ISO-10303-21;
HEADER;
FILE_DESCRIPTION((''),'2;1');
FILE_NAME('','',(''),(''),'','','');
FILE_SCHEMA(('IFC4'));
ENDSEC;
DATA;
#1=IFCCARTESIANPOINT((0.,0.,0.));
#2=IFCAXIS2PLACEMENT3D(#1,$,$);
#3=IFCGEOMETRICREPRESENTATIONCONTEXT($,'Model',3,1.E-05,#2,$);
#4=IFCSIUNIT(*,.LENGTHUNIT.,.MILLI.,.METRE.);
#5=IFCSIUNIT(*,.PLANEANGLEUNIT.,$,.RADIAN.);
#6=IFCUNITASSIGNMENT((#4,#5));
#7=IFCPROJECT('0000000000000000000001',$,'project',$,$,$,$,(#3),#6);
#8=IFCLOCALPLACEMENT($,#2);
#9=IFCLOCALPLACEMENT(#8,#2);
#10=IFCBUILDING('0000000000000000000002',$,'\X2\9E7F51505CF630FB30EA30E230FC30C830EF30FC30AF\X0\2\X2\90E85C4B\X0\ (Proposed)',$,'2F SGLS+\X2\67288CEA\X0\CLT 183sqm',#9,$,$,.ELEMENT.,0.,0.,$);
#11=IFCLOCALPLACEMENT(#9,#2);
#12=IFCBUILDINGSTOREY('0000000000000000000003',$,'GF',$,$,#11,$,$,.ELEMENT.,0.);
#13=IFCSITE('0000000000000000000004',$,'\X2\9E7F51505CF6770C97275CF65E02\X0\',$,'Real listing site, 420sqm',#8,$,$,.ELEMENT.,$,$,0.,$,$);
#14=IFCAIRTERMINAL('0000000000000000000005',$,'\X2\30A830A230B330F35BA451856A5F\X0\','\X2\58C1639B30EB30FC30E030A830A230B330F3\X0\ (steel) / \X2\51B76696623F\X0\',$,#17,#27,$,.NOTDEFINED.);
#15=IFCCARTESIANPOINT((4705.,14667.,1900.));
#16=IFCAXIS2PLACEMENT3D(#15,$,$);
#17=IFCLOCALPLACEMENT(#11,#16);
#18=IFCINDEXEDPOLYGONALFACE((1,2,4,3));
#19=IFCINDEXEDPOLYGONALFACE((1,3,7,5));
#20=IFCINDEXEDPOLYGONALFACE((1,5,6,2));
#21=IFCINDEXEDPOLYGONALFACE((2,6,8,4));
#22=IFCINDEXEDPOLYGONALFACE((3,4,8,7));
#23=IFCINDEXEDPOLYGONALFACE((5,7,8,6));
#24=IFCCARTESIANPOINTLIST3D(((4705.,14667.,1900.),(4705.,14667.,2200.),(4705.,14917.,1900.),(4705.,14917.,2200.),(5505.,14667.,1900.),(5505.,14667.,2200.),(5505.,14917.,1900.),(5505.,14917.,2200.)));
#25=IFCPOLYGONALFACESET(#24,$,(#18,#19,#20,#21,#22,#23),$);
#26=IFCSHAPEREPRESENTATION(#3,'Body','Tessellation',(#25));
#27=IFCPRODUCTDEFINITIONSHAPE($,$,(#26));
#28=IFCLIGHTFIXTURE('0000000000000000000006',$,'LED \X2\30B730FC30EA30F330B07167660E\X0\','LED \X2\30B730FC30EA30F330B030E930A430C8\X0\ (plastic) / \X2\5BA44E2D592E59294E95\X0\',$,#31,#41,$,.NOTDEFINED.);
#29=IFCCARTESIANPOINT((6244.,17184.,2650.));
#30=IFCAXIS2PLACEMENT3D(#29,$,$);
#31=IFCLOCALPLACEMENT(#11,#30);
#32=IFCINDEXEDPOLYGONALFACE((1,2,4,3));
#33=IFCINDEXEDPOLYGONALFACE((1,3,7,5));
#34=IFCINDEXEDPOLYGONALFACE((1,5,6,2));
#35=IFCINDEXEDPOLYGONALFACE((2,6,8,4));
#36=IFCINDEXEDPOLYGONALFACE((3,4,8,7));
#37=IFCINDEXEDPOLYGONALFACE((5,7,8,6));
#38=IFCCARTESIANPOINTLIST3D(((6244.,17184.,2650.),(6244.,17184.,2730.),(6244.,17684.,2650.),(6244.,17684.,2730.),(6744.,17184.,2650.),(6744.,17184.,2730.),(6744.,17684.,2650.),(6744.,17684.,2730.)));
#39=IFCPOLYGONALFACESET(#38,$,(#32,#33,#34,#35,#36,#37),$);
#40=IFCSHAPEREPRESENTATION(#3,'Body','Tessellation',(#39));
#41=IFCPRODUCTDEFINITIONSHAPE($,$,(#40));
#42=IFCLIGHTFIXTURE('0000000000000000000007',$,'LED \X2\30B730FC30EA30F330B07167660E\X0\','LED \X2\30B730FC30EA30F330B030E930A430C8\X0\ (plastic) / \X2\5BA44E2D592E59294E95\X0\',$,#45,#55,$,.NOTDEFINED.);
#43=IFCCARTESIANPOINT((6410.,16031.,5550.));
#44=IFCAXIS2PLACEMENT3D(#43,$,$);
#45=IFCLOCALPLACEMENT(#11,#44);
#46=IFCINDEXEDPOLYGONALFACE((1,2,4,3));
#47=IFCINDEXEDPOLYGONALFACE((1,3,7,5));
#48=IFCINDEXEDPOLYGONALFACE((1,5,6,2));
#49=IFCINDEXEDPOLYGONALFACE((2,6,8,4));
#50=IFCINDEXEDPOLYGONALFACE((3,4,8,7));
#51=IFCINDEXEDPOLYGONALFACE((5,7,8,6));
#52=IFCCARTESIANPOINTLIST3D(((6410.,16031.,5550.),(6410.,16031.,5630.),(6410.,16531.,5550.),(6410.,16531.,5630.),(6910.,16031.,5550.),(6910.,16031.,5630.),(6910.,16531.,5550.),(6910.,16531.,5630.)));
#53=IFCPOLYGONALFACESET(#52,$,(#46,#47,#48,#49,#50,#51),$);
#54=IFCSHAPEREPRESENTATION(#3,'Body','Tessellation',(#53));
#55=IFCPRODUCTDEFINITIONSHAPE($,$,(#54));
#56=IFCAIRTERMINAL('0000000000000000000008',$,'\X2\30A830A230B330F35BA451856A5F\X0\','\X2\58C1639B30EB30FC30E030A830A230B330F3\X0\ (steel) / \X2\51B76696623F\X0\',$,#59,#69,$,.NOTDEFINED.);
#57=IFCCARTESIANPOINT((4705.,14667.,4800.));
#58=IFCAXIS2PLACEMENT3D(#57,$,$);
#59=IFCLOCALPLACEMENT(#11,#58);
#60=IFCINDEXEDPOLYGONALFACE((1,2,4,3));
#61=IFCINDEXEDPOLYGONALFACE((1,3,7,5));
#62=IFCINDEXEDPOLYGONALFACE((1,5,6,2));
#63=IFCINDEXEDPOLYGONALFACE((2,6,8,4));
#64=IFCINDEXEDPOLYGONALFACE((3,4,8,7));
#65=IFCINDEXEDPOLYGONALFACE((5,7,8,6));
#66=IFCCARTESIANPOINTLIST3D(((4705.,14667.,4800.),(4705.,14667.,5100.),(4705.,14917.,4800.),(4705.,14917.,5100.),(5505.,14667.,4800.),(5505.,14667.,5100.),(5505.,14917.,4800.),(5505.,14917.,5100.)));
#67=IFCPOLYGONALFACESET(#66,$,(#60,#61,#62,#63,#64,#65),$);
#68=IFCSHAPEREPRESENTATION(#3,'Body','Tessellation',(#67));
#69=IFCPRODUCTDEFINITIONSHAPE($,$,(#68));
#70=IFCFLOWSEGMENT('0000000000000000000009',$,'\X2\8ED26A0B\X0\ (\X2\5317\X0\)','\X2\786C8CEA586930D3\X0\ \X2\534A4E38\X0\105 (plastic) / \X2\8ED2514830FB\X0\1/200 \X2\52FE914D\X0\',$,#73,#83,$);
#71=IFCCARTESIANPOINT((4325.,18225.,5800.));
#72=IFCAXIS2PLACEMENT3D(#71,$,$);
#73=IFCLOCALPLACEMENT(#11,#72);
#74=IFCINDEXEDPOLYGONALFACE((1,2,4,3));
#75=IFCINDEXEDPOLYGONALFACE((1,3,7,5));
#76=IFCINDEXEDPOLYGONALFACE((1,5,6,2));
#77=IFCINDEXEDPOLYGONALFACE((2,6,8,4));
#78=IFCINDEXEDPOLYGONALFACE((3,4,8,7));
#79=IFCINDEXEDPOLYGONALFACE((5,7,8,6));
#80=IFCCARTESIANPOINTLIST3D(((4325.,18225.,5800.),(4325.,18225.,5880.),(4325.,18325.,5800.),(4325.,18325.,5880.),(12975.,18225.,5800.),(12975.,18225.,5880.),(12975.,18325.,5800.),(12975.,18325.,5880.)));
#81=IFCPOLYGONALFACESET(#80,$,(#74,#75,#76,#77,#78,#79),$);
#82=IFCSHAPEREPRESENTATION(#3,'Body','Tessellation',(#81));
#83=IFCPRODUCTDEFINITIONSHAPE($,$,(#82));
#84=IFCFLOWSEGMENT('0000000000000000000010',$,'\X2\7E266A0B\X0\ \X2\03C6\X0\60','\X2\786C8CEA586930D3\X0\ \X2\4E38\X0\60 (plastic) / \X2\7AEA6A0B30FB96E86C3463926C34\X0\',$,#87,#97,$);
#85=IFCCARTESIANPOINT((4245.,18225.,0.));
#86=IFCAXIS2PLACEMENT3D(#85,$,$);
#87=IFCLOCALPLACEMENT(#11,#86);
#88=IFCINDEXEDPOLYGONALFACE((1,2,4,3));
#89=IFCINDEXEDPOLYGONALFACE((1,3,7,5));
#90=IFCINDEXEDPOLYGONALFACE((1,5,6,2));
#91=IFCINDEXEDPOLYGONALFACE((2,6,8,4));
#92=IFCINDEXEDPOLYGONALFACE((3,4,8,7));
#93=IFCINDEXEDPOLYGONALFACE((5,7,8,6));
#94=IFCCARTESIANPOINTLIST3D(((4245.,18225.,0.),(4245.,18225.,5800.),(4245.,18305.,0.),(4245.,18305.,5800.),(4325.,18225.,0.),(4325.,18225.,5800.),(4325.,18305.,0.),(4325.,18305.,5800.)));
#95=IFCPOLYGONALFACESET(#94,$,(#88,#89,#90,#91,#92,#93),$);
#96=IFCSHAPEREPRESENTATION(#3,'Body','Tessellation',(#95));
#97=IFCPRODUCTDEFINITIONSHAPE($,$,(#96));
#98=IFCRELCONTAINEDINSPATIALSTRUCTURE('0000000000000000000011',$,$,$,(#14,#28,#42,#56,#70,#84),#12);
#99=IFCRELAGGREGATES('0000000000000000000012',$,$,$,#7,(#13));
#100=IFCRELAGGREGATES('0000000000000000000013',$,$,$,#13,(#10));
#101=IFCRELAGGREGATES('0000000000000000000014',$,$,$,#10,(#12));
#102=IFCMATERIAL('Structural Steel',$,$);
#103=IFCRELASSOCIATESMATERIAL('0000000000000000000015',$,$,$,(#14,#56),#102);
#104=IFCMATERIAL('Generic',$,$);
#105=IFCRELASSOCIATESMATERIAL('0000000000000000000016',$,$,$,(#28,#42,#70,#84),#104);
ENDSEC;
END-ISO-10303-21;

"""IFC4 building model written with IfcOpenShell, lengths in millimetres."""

from ifc_helpers import new_model, si_unit, frame, frame_2d, origin, place, context, project, spatial, rectangle, extrude, material, element, save


model = new_model("IFC4")

# Units and contexts
model_context = context("Model", 3, precision=1e-05, world=origin())
ifc_project = project(units=[si_unit("LENGTHUNIT", "METRE", prefix="MILLI"), si_unit("PLANEANGLEUNIT", "RADIAN")], contexts=[model_context])

# Site, building, storey
site_placement = place(None, origin())
site = spatial("IfcSite", under=ifc_project, at=site_placement, Name="鹿児島県霧島市", ObjectType="Real listing site, 420sqm", CompositionType="ELEMENT", RefElevation=0.0)
building_placement = place(site_placement, origin())
building = spatial("IfcBuilding", under=site, at=building_placement, Name="鹿児島・リモートワーク2部屋 (Proposed)", ObjectType="2F SGLS+木質CLT 183sqm", CompositionType="ELEMENT", ElevationOfRefHeight=0.0, ElevationOfTerrain=0.0)
storey_placement = place(building_placement, origin())
storey = spatial("IfcBuildingStorey", under=building, at=storey_placement, Name="GF", CompositionType="ELEMENT", Elevation=0.0)

# Shared definitions
ifc_material_1 = material(Name="Generic")

# Shared definitions
ifc_material_2 = material(Name="Structural Steel")

# Air terminal
air_terminal_1_placement = place(storey_placement, frame((4705.0, 14667.0, 1900.0)))
element("IfcAirTerminal", 1, at=air_terminal_1_placement, inside=storey, material=ifc_material_2, Name="エアコン室内機", Description="壁掛ルームエアコン (steel) / 冷暖房", PredefinedType="NOTDEFINED", context=model_context, shape_type="SweptSolid", body=[
    extrude(rectangle(XDim=800.0, YDim=250.0, at=frame_2d((400.0, 125.0))), frame((4705.0, 14667.0, 1900.0)), (0.0, 0.0, 1.0), 300.0),
])

# Light fixtures
light_fixture_1_placement = place(storey_placement, frame((6244.0, 17184.0, 2650.0)))
element("IfcLightFixture", 2, at=light_fixture_1_placement, inside=storey, material=ifc_material_1, Name="LED シーリング照明", Description="LED シーリングライト (plastic) / 室中央天井", PredefinedType="NOTDEFINED", context=model_context, shape_type="SweptSolid", body=[
    extrude(rectangle(XDim=500.0, YDim=500.0, at=frame_2d((250.0, 250.0))), frame((6244.0, 17184.0, 2650.0)), (0.0, 0.0, 1.0), 80.0),
])
light_fixture_2_placement = place(storey_placement, frame((6410.0, 16031.0, 5550.0)))
element("IfcLightFixture", 3, at=light_fixture_2_placement, inside=storey, material=ifc_material_1, Name="LED シーリング照明", Description="LED シーリングライト (plastic) / 室中央天井", PredefinedType="NOTDEFINED", context=model_context, shape_type="SweptSolid", body=[
    extrude(rectangle(XDim=500.0, YDim=500.0, at=frame_2d((250.0, 250.0))), frame((6410.0, 16031.0, 5550.0)), (0.0, 0.0, 1.0), 80.0),
])

# Air terminal
air_terminal_2_placement = place(storey_placement, frame((4705.0, 14667.0, 4800.0)))
element("IfcAirTerminal", 4, at=air_terminal_2_placement, inside=storey, material=ifc_material_2, Name="エアコン室内機", Description="壁掛ルームエアコン (steel) / 冷暖房", PredefinedType="NOTDEFINED", context=model_context, shape_type="SweptSolid", body=[
    extrude(rectangle(XDim=800.0, YDim=250.0, at=frame_2d((400.0, 125.0))), frame((4705.0, 14667.0, 4800.0)), (0.0, 0.0, 1.0), 300.0),
])

# Flow segments
flow_segment_1_placement = place(storey_placement, frame((4325.0, 18225.0, 5800.0)))
element("IfcFlowSegment", 5, at=flow_segment_1_placement, inside=storey, material=ifc_material_1, Name="軒樋 (北)", Description="硬質塩ビ 半丸105 (plastic) / 軒先・1/200 勾配", context=model_context, shape_type="SweptSolid", body=[
    extrude(rectangle(XDim=8650.0, YDim=100.0, at=frame_2d((4325.0, 50.0))), frame((4325.0, 18225.0, 5800.0)), (0.0, 0.0, 1.0), 80.0),
])
flow_segment_2_placement = place(storey_placement, frame((4245.0, 18225.0, 0.0)))
element("IfcFlowSegment", 6, at=flow_segment_2_placement, inside=storey, material=ifc_material_1, Name="縦樋 φ60", Description="硬質塩ビ 丸60 (plastic) / 竪樋・雨水排水", context=model_context, shape_type="SweptSolid", body=[
    extrude(rectangle(XDim=80.0, YDim=80.0, at=frame_2d((40.0, 40.0))), frame((4245.0, 18225.0, 0.0)), (0.0, 0.0, 1.0), 5800.0),
])

save(model, "model.ifc")
